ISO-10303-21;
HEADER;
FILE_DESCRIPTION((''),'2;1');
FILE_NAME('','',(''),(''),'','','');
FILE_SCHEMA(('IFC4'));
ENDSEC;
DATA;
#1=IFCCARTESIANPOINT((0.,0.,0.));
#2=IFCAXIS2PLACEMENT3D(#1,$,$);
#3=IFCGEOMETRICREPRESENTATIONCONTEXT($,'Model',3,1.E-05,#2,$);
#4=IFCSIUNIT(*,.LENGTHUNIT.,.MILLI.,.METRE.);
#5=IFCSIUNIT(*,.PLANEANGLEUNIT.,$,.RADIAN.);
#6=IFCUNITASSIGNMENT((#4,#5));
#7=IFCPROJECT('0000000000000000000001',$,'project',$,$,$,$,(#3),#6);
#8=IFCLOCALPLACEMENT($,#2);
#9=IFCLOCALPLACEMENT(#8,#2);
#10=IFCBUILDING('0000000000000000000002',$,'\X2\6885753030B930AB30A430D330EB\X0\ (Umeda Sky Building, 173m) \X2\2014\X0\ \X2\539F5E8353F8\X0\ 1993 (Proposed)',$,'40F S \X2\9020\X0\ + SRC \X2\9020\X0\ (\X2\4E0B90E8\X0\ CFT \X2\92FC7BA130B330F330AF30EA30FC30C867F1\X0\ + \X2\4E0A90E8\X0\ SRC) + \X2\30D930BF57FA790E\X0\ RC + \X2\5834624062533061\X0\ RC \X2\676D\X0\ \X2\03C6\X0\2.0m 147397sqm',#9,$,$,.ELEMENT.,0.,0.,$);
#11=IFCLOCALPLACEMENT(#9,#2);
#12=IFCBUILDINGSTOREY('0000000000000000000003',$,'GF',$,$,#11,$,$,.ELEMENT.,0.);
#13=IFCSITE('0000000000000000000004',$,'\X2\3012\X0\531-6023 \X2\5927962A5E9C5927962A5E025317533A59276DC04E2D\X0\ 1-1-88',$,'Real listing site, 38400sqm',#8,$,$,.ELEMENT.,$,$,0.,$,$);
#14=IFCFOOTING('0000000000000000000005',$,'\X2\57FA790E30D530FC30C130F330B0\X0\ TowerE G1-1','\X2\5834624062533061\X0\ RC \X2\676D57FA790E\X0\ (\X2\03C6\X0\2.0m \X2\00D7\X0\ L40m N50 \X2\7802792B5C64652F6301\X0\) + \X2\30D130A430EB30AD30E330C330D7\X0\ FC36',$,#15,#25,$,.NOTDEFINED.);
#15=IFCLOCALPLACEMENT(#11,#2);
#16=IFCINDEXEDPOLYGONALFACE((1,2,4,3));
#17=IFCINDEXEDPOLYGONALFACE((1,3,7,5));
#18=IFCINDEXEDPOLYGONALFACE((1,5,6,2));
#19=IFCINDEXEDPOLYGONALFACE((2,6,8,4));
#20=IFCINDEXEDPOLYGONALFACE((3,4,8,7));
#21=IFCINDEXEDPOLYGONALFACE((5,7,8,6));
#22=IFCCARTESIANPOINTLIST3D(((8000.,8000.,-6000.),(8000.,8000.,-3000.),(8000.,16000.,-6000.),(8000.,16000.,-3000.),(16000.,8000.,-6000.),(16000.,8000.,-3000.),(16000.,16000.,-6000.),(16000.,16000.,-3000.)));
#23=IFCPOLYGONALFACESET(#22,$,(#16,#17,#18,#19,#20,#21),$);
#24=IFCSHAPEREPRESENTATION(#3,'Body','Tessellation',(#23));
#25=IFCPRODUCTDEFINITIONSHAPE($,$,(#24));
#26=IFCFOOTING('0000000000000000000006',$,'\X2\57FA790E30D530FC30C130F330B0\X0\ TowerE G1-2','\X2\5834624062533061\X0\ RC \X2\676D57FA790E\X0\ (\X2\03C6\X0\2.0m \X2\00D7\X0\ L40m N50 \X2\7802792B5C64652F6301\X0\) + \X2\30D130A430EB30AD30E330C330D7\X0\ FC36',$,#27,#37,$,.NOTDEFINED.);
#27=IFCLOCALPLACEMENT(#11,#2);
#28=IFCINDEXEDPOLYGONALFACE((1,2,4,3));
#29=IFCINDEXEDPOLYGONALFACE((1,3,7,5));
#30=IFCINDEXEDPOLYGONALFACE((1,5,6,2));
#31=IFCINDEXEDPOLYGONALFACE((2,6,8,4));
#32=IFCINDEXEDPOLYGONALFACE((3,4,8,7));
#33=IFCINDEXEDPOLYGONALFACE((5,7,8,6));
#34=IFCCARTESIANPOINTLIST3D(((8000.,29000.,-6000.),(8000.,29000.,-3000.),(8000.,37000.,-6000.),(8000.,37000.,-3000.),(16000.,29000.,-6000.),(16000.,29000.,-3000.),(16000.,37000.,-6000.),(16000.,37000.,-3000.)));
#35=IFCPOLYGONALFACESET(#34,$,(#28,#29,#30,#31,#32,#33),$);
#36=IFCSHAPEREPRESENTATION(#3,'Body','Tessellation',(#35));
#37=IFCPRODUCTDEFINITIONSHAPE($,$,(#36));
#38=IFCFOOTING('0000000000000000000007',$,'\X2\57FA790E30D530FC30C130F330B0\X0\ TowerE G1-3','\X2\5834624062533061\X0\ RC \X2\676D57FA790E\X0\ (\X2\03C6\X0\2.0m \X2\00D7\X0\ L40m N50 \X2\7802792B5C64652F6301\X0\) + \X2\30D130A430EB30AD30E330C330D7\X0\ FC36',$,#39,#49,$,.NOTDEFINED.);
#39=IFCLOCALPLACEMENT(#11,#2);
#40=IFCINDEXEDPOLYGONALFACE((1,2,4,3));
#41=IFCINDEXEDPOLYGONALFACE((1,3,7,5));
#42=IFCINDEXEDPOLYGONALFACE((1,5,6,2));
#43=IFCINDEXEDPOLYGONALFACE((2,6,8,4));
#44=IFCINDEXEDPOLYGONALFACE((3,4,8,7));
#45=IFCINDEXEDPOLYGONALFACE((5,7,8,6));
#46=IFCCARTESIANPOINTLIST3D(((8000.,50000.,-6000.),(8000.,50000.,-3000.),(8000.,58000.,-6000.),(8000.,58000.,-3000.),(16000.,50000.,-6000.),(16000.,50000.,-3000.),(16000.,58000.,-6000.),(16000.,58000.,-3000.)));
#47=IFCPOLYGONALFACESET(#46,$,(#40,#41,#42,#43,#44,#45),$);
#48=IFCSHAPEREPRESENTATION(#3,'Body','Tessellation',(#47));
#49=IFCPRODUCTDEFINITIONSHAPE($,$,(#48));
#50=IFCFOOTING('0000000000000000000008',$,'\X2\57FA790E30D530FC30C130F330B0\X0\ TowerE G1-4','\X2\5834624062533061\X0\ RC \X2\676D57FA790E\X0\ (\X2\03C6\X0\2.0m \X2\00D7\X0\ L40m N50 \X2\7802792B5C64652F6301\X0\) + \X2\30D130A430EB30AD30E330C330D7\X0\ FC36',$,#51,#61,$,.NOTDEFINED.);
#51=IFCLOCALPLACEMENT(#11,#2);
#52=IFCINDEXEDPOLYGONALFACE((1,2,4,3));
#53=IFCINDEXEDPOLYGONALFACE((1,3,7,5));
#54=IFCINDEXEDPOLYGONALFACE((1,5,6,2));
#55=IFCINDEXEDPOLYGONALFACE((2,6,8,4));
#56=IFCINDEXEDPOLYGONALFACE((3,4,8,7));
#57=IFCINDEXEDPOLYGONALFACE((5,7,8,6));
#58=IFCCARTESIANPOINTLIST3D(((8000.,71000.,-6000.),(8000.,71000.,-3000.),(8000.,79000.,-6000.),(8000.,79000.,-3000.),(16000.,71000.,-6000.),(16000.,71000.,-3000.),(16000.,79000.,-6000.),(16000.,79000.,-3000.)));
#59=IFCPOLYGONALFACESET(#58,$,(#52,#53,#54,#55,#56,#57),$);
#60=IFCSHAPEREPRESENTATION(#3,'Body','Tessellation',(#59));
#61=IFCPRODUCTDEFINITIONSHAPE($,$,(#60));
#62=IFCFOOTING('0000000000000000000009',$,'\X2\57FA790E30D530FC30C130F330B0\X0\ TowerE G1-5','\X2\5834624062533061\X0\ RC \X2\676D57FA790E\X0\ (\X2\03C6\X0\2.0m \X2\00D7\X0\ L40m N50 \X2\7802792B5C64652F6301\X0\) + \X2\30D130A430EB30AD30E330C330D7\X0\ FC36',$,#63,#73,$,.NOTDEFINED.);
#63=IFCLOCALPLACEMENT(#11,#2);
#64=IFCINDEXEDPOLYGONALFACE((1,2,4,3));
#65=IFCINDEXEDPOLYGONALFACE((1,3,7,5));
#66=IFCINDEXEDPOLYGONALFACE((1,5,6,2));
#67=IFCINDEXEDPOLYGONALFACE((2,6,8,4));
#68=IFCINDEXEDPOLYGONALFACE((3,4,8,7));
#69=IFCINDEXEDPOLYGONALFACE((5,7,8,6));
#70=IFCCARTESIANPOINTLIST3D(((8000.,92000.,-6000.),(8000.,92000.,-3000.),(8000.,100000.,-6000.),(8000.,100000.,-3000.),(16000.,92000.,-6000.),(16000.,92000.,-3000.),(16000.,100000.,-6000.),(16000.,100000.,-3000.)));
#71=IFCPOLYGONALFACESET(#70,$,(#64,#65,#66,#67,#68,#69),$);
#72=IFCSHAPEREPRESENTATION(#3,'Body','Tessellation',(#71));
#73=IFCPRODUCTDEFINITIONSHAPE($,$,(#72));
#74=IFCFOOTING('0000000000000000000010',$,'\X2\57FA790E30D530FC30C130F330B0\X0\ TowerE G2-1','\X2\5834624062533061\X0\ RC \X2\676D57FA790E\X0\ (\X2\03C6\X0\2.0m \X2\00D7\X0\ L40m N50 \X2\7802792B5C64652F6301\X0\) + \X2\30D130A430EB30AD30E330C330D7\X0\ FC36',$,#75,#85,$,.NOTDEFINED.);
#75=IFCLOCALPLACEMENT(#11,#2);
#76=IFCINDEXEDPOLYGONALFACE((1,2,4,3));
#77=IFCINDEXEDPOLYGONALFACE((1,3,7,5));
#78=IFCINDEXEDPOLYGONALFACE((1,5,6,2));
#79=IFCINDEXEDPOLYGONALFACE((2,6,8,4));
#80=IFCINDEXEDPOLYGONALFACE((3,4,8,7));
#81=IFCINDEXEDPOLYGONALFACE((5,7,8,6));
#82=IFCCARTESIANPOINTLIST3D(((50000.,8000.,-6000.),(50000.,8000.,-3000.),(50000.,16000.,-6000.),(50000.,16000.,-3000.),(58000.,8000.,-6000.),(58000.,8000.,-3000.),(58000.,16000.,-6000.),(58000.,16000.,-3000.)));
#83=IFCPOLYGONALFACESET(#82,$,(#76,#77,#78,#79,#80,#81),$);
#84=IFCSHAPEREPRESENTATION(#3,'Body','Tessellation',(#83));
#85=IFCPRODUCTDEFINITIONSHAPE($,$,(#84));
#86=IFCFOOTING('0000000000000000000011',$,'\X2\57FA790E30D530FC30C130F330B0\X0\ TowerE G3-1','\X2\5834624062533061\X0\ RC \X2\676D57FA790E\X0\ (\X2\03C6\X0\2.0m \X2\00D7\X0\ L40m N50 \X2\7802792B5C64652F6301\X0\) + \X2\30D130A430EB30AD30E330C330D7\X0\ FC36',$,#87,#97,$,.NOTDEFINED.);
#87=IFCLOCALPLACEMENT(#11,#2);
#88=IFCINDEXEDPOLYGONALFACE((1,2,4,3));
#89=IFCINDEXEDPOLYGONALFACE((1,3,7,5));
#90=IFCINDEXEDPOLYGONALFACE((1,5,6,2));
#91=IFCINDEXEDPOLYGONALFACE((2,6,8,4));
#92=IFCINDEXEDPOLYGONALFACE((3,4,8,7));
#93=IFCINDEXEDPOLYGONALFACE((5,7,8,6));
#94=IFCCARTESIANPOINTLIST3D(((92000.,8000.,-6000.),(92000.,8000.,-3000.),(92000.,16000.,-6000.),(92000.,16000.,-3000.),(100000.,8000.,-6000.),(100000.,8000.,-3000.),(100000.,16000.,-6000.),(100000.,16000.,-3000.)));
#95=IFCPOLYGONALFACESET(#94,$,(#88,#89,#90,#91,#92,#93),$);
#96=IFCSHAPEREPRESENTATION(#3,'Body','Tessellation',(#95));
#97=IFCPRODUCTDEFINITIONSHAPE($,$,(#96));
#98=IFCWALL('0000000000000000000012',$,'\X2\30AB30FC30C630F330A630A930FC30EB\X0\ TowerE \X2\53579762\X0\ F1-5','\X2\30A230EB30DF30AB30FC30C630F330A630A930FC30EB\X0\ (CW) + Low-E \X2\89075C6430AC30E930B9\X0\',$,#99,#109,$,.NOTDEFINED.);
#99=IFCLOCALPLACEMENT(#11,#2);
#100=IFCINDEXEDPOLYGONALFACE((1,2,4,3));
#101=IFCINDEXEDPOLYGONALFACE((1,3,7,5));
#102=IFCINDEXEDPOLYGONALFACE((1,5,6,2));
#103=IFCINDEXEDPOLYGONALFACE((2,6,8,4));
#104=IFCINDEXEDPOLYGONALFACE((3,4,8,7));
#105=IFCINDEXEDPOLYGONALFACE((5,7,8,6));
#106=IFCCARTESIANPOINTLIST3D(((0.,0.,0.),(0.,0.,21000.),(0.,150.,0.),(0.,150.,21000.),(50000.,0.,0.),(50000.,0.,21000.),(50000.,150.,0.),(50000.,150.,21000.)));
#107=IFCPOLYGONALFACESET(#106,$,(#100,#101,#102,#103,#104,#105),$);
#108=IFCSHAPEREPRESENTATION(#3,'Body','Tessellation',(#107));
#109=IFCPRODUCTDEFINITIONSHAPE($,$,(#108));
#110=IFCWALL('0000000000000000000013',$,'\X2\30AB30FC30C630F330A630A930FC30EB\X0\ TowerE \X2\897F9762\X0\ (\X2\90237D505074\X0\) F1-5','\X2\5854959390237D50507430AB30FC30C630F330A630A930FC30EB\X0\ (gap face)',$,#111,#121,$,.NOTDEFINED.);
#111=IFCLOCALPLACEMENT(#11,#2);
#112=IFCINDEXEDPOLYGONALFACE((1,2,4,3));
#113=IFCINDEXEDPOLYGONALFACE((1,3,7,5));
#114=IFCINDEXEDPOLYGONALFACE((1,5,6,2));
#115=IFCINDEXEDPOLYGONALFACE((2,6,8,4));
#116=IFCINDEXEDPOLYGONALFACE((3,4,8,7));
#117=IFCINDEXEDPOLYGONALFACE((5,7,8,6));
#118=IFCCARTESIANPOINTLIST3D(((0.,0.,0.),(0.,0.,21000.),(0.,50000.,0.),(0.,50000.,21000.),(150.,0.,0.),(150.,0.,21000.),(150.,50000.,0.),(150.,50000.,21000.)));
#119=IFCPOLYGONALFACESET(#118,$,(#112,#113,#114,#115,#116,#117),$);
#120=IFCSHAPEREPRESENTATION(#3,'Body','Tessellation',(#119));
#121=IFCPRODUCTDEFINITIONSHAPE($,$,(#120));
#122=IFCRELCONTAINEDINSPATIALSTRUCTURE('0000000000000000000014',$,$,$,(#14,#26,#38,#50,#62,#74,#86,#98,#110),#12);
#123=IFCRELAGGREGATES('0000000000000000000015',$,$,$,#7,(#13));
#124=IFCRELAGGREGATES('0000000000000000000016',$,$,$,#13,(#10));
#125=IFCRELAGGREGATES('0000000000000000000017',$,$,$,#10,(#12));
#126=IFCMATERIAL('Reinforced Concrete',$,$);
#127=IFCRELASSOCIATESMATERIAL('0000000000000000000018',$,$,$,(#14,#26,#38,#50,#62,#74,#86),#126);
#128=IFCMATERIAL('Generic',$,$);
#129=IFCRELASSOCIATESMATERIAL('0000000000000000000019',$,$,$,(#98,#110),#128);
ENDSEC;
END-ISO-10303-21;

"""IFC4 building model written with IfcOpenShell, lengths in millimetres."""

from ifc_helpers import new_model, si_unit, frame, frame_2d, origin, place, context, project, spatial, rectangle, extrude, material, element, save


model = new_model("IFC4")

# Units and contexts
model_context = context("Model", 3, precision=1e-05, world=origin())
ifc_project = project(units=[si_unit("LENGTHUNIT", "METRE", prefix="MILLI"), si_unit("PLANEANGLEUNIT", "RADIAN")], contexts=[model_context])

# Site, building, storey
site_placement = place(None, origin())
site = spatial("IfcSite", under=ifc_project, at=site_placement, Name="〒531-6023 大阪府大阪市北区大淀中 1-1-88", ObjectType="Real listing site, 38400sqm", CompositionType="ELEMENT", RefElevation=0.0)
building_placement = place(site_placement, origin())
building = spatial("IfcBuilding", under=site, at=building_placement, Name="梅田スカイビル (Umeda Sky Building, 173m) — 原広司 1993 (Proposed)", ObjectType="40F S 造 + SRC 造 (下部 CFT 鋼管コンクリート柱 + 上部 SRC) + ベタ基礎 RC + 場所打ち RC 杭 φ2.0m 147397sqm", CompositionType="ELEMENT", ElevationOfRefHeight=0.0, ElevationOfTerrain=0.0)
storey_placement = place(building_placement, origin())
storey = spatial("IfcBuildingStorey", under=building, at=storey_placement, Name="GF", CompositionType="ELEMENT", Elevation=0.0)

# Footings
ifc_material_1 = material(Name="Reinforced Concrete")
footing_1_placement = place(storey_placement, frame((4000.0, 4000.0, -3000.0)))
element("IfcFooting", 1, at=footing_1_placement, inside=storey, material=ifc_material_1, Name="基礎フーチング TowerE G1-1", Description="場所打ち RC 杭基礎 (φ2.0m × L40m N50 砂礫層支持) + パイルキャップ FC36", PredefinedType="NOTDEFINED", context=model_context, shape_type="SweptSolid", body=[
    extrude(rectangle(XDim=8000.0, YDim=8000.0, at=frame_2d((4000.0, 4000.0))), frame((4000.0, 4000.0, -3000.0)), (0.0, 0.0, 1.0), 3000.0),
])
footing_2_placement = place(storey_placement, frame((4000.0, 14500.0, -3000.0)))
element("IfcFooting", 2, at=footing_2_placement, inside=storey, material=ifc_material_1, Name="基礎フーチング TowerE G1-2", Description="場所打ち RC 杭基礎 (φ2.0m × L40m N50 砂礫層支持) + パイルキャップ FC36", PredefinedType="NOTDEFINED", context=model_context, shape_type="SweptSolid", body=[
    extrude(rectangle(XDim=8000.0, YDim=8000.0, at=frame_2d((4000.0, 4000.0))), frame((4000.0, 14500.0, -3000.0)), (0.0, 0.0, 1.0), 3000.0),
])
footing_3_placement = place(storey_placement, frame((4000.0, 25000.0, -3000.0)))
element("IfcFooting", 3, at=footing_3_placement, inside=storey, material=ifc_material_1, Name="基礎フーチング TowerE G1-3", Description="場所打ち RC 杭基礎 (φ2.0m × L40m N50 砂礫層支持) + パイルキャップ FC36", PredefinedType="NOTDEFINED", context=model_context, shape_type="SweptSolid", body=[
    extrude(rectangle(XDim=8000.0, YDim=8000.0, at=frame_2d((4000.0, 4000.0))), frame((4000.0, 25000.0, -3000.0)), (0.0, 0.0, 1.0), 3000.0),
])
footing_4_placement = place(storey_placement, frame((4000.0, 35500.0, -3000.0)))
element("IfcFooting", 4, at=footing_4_placement, inside=storey, material=ifc_material_1, Name="基礎フーチング TowerE G1-4", Description="場所打ち RC 杭基礎 (φ2.0m × L40m N50 砂礫層支持) + パイルキャップ FC36", PredefinedType="NOTDEFINED", context=model_context, shape_type="SweptSolid", body=[
    extrude(rectangle(XDim=8000.0, YDim=8000.0, at=frame_2d((4000.0, 4000.0))), frame((4000.0, 35500.0, -3000.0)), (0.0, 0.0, 1.0), 3000.0),
])
footing_5_placement = place(storey_placement, frame((4000.0, 46000.0, -3000.0)))
element("IfcFooting", 5, at=footing_5_placement, inside=storey, material=ifc_material_1, Name="基礎フーチング TowerE G1-5", Description="場所打ち RC 杭基礎 (φ2.0m × L40m N50 砂礫層支持) + パイルキャップ FC36", PredefinedType="NOTDEFINED", context=model_context, shape_type="SweptSolid", body=[
    extrude(rectangle(XDim=8000.0, YDim=8000.0, at=frame_2d((4000.0, 4000.0))), frame((4000.0, 46000.0, -3000.0)), (0.0, 0.0, 1.0), 3000.0),
])
footing_6_placement = place(storey_placement, frame((25000.0, 4000.0, -3000.0)))
element("IfcFooting", 6, at=footing_6_placement, inside=storey, material=ifc_material_1, Name="基礎フーチング TowerE G2-1", Description="場所打ち RC 杭基礎 (φ2.0m × L40m N50 砂礫層支持) + パイルキャップ FC36", PredefinedType="NOTDEFINED", context=model_context, shape_type="SweptSolid", body=[
    extrude(rectangle(XDim=8000.0, YDim=8000.0, at=frame_2d((4000.0, 4000.0))), frame((25000.0, 4000.0, -3000.0)), (0.0, 0.0, 1.0), 3000.0),
])
footing_7_placement = place(storey_placement, frame((46000.0, 4000.0, -3000.0)))
element("IfcFooting", 7, at=footing_7_placement, inside=storey, material=ifc_material_1, Name="基礎フーチング TowerE G3-1", Description="場所打ち RC 杭基礎 (φ2.0m × L40m N50 砂礫層支持) + パイルキャップ FC36", PredefinedType="NOTDEFINED", context=model_context, shape_type="SweptSolid", body=[
    extrude(rectangle(XDim=8000.0, YDim=8000.0, at=frame_2d((4000.0, 4000.0))), frame((46000.0, 4000.0, -3000.0)), (0.0, 0.0, 1.0), 3000.0),
])

# Walls
ifc_material_2 = material(Name="Generic")
wall_1_placement = place(storey_placement, origin())
element("IfcWall", 8, at=wall_1_placement, inside=storey, material=ifc_material_2, Name="カーテンウォール TowerE 南面 F1-5", Description="アルミカーテンウォール (CW) + Low-E 複層ガラス", PredefinedType="NOTDEFINED", context=model_context, shape_type="SweptSolid", body=[
    extrude(rectangle(XDim=50000.0, YDim=150.0, at=frame_2d((25000.0, 75.0))), origin(), (0.0, 0.0, 1.0), 21000.0),
])
wall_2_placement = place(storey_placement, origin())
element("IfcWall", 9, at=wall_2_placement, inside=storey, material=ifc_material_2, Name="カーテンウォール TowerE 西面 (連結側) F1-5", Description="塔間連結側カーテンウォール (gap face)", PredefinedType="NOTDEFINED", context=model_context, shape_type="SweptSolid", body=[
    extrude(rectangle(XDim=150.0, YDim=50000.0, at=frame_2d((75.0, 25000.0))), origin(), (0.0, 0.0, 1.0), 21000.0),
])

save(model, "model.ifc")
